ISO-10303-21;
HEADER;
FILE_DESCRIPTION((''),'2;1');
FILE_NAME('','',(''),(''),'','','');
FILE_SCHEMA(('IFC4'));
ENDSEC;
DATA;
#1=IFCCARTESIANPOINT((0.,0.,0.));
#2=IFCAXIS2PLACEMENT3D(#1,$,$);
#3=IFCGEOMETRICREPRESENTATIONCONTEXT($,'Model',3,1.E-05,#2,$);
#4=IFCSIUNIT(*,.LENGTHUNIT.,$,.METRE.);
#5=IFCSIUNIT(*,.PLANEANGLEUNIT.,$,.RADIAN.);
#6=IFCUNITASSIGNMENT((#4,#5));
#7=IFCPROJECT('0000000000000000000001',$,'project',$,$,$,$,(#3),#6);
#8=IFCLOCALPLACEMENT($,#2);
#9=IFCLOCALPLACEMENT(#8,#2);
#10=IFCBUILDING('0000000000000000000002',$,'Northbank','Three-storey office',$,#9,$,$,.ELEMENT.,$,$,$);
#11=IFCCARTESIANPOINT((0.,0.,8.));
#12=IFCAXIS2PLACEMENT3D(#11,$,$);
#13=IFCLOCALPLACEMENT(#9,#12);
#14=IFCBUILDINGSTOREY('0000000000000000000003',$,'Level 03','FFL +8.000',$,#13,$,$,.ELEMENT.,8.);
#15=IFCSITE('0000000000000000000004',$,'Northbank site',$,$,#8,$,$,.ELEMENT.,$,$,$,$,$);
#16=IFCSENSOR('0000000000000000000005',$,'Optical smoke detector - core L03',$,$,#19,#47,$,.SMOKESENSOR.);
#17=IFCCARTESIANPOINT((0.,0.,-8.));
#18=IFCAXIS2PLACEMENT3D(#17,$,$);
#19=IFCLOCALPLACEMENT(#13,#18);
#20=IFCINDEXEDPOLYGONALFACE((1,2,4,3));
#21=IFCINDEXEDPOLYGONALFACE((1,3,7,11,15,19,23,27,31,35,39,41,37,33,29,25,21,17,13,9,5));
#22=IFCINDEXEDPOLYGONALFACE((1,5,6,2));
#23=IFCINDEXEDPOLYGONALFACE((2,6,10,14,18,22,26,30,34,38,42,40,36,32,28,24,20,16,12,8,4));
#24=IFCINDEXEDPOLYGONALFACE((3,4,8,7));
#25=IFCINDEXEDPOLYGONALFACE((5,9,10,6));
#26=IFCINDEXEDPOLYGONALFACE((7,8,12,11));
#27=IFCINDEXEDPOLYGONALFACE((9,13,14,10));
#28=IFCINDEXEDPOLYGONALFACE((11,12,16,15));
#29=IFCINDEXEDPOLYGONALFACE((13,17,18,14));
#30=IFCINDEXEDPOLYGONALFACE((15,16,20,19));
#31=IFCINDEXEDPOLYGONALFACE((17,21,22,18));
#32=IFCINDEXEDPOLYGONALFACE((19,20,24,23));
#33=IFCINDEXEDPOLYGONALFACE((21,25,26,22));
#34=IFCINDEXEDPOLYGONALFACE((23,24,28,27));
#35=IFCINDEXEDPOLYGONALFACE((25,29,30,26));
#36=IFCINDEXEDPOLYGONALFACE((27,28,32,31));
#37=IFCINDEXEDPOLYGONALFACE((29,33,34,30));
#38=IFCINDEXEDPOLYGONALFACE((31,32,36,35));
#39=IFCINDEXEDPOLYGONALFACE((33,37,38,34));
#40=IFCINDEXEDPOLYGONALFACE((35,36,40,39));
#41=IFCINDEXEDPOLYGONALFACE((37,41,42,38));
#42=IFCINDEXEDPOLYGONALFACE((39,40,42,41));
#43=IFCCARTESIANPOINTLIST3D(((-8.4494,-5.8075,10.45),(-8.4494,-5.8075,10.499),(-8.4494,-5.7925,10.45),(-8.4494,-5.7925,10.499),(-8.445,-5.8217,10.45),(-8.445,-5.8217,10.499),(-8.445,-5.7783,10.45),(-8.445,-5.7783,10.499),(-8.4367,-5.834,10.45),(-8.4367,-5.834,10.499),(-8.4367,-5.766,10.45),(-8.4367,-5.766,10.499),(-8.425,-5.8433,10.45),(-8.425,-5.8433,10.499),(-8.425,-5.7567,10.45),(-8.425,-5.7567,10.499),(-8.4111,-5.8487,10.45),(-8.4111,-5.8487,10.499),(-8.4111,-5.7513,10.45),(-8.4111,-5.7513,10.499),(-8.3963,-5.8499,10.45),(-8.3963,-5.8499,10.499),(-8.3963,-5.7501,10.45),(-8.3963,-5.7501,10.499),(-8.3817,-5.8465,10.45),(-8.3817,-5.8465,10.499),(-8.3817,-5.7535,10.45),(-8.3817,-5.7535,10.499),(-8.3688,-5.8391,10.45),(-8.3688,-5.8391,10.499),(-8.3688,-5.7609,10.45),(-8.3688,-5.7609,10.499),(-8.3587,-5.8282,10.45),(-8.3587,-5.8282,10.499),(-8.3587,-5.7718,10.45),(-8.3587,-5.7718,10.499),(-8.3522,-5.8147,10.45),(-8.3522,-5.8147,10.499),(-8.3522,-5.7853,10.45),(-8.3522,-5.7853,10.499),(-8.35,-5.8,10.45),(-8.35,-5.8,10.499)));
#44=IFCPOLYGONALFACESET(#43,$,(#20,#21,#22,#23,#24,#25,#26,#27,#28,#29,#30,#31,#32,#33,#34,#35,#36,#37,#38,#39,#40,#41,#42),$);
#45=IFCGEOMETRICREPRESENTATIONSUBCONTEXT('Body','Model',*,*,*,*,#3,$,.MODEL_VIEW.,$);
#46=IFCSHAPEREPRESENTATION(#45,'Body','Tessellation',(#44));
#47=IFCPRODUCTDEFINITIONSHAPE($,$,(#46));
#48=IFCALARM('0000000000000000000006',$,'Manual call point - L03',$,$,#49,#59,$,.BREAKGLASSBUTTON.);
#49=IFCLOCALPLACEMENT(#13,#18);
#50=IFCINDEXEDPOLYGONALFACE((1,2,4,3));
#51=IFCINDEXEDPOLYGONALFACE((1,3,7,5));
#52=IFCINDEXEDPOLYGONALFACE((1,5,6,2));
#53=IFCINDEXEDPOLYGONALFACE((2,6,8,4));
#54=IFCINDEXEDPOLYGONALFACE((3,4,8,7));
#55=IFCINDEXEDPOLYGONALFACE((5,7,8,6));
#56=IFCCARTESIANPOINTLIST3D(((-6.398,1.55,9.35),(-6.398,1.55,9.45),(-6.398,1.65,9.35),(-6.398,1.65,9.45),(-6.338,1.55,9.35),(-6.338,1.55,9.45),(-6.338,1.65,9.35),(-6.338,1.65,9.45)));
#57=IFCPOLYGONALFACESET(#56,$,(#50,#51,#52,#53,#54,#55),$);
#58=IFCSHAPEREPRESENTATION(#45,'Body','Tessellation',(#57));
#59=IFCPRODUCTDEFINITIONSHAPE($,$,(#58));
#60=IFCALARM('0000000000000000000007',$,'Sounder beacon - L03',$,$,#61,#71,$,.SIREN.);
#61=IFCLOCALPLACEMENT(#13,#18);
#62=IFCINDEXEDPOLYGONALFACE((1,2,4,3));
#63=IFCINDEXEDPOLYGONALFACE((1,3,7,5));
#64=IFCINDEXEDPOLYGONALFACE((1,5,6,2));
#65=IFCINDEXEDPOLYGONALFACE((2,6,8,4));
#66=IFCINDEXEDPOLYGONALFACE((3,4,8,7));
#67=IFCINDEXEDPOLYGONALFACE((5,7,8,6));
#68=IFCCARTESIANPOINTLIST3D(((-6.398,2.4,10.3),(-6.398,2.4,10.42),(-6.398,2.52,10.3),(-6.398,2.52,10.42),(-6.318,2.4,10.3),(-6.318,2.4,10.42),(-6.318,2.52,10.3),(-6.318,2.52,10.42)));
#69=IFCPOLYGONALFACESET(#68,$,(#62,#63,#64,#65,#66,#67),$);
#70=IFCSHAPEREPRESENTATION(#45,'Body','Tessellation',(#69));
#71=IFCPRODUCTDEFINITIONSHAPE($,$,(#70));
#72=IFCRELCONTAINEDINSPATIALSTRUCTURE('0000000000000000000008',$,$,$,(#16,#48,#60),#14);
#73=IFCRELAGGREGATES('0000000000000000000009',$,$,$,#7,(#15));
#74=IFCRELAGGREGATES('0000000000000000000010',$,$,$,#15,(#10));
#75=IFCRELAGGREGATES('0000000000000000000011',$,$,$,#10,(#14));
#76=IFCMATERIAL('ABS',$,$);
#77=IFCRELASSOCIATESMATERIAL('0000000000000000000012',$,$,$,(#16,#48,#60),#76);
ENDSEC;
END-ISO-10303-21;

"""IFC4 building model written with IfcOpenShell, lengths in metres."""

from ifc_helpers import new_model, si_unit, frame, origin, place, context, subcontext, project, spatial, rectangle, circle, extrude, material, element, save


model = new_model("IFC4")

# Units and contexts
model_context = context("Model", 3, precision=1e-05, world=origin())
body_context = subcontext(model_context, "Body", "Model", "MODEL_VIEW")
ifc_project = project(units=[si_unit("LENGTHUNIT", "METRE"), si_unit("PLANEANGLEUNIT", "RADIAN")], contexts=[model_context])

# Site, building, storey
site_placement = place(None, origin())
site = spatial("IfcSite", under=ifc_project, at=site_placement, Name="Northbank site", CompositionType="ELEMENT")
building_placement = place(site_placement, origin())
building = spatial("IfcBuilding", under=site, at=building_placement, Name="Northbank", Description="Three-storey office", CompositionType="ELEMENT")
storey_placement = place(building_placement, frame((0.0, 0.0, 8.0)))
storey = spatial("IfcBuildingStorey", under=building, at=storey_placement, Name="Level 03", Description="FFL +8.000", CompositionType="ELEMENT", Elevation=8.0)

# Sensor
ifc_material_1 = material(Name="ABS")
sensor_1_placement = place(storey_placement, frame((0.0, 0.0, -8.0)))
element("IfcSensor", 1, at=sensor_1_placement, inside=storey, material=ifc_material_1, Name="Optical smoke detector - core L03", PredefinedType="SMOKESENSOR", context=body_context, shape_type="SweptSolid", body=[
    extrude(circle(Radius=0.05), frame((-8.4, -5.8, 10.45), z_axis=(0.0, 0.0, 1.0), x_axis=(1.0, 0.0, 0.0)), (0.0, 0.0, 1.0), 0.049),
])

# Alarms
alarm_1_placement = place(storey_placement, frame((0.0, 0.0, -8.0)))
element("IfcAlarm", 2, at=alarm_1_placement, inside=storey, material=ifc_material_1, Name="Manual call point - L03", PredefinedType="BREAKGLASSBUTTON", context=body_context, shape_type="SweptSolid", body=[
    extrude(rectangle(XDim=0.06, YDim=0.1), frame((-6.368, 1.6, 9.35)), (0.0, 0.0, 1.0), 0.1),
])
alarm_2_placement = place(storey_placement, frame((0.0, 0.0, -8.0)))
element("IfcAlarm", 3, at=alarm_2_placement, inside=storey, material=ifc_material_1, Name="Sounder beacon - L03", PredefinedType="SIREN", context=body_context, shape_type="SweptSolid", body=[
    extrude(rectangle(XDim=0.08, YDim=0.12), frame((-6.358, 2.46, 10.3)), (0.0, 0.0, 1.0), 0.12),
])

save(model, "model.ifc")
